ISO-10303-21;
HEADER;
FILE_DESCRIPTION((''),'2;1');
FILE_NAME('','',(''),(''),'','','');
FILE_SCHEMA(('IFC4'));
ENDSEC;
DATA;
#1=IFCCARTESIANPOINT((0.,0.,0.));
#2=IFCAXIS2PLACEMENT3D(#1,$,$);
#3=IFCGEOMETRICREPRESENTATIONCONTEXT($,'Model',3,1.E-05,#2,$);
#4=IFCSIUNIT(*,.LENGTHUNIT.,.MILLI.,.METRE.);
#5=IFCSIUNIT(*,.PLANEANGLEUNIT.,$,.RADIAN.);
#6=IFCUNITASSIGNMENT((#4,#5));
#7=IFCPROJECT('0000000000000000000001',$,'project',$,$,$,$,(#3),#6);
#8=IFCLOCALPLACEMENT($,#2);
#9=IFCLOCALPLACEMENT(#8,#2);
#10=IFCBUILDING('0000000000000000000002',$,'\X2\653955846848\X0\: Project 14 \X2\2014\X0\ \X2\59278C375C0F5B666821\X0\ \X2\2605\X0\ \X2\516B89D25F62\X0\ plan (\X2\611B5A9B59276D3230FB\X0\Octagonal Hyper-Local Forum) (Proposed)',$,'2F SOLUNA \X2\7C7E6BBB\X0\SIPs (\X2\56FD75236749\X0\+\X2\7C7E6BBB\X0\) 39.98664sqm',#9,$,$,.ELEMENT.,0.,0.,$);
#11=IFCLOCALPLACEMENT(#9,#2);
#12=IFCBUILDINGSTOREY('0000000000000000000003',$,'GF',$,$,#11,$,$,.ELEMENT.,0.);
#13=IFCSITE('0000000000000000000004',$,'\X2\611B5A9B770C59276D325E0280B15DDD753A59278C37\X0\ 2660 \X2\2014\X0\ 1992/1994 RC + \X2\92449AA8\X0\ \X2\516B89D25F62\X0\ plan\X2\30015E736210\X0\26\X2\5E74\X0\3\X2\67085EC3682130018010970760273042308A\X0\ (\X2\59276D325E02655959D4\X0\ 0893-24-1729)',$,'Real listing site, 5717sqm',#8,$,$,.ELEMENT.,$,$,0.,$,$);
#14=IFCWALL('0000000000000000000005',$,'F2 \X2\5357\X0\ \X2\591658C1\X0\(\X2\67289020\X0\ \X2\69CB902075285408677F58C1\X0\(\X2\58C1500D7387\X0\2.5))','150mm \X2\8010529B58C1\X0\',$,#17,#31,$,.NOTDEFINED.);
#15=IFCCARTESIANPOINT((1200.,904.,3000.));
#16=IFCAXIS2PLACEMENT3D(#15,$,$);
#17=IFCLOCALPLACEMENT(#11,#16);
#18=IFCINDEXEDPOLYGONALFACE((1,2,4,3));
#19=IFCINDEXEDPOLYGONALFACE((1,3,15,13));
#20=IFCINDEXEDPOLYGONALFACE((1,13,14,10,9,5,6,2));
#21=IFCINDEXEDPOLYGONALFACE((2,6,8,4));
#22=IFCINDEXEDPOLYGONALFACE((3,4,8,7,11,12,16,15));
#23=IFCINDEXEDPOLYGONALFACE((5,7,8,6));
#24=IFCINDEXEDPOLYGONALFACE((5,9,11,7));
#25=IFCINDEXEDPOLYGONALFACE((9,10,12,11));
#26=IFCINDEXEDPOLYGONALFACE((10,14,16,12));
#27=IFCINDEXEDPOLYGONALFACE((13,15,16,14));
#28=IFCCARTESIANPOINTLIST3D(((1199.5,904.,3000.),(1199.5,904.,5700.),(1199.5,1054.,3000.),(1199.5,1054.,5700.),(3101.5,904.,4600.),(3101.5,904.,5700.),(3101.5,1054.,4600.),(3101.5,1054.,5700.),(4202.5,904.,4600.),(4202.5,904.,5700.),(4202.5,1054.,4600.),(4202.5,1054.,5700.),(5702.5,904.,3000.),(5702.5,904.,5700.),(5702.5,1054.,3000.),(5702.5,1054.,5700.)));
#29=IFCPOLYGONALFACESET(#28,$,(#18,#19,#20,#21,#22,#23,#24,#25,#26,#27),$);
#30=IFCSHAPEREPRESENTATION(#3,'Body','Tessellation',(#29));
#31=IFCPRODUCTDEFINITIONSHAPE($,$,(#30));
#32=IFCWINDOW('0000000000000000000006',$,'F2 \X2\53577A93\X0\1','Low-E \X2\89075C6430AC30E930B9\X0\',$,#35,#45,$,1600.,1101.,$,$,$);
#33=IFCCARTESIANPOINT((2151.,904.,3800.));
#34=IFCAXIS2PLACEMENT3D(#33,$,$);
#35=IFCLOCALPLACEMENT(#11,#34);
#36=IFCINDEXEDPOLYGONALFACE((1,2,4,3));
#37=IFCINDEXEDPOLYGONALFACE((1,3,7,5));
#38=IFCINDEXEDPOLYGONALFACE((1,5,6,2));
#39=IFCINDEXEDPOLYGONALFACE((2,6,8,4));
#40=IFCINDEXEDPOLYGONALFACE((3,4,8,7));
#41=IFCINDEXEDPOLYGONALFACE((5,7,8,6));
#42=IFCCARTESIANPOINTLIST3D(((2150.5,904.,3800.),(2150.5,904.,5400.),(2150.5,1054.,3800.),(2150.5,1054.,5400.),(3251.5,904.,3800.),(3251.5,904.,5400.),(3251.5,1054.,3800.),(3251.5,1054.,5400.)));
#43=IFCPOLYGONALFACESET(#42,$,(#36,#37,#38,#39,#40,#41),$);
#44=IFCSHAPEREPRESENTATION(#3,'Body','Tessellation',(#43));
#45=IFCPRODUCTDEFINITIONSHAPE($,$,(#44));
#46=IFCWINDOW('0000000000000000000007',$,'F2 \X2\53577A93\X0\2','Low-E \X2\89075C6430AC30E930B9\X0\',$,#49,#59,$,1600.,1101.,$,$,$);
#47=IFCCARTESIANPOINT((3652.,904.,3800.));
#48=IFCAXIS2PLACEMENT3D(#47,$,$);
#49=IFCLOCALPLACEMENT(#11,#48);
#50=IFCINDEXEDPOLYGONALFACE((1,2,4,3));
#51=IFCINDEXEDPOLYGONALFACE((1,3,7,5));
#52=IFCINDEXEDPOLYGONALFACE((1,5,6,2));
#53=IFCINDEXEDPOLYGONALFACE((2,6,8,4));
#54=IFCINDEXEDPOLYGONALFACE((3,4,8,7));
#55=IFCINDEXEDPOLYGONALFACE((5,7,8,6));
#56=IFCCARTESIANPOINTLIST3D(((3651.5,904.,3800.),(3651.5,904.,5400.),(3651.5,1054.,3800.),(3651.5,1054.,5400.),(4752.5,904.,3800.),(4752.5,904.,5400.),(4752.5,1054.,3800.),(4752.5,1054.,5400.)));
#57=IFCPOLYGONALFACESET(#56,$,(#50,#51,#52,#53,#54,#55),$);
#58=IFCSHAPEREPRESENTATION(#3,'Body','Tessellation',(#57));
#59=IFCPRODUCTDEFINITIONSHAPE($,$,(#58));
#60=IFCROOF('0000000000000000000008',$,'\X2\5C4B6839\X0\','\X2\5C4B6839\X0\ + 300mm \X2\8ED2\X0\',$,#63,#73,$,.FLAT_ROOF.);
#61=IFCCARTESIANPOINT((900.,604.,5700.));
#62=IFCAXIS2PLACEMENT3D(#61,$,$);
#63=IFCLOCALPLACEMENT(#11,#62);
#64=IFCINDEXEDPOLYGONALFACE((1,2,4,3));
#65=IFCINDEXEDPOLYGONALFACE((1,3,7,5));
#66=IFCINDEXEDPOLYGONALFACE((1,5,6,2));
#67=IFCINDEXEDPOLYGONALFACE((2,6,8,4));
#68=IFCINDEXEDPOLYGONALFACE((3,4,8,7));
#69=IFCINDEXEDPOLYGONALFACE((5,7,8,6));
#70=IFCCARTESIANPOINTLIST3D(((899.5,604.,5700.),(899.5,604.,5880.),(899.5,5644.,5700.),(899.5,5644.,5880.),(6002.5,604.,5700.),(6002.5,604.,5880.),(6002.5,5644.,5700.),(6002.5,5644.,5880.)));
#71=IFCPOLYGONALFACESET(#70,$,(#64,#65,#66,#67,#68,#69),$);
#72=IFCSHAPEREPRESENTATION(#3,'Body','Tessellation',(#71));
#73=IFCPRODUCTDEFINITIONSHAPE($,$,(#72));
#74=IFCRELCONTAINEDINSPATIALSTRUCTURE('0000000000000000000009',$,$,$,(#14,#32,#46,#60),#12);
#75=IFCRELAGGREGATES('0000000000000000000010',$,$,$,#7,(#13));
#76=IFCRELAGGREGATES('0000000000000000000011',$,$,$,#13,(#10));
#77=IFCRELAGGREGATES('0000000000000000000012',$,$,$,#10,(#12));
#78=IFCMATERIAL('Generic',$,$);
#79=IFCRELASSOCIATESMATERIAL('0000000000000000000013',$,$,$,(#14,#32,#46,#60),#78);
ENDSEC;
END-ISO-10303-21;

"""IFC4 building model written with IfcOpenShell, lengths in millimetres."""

from ifc_helpers import new_model, si_unit, frame, frame_2d, origin, place, context, project, spatial, rectangle, extrude, material, element, fill, save


model = new_model("IFC4")

# Units and contexts
model_context = context("Model", 3, precision=1e-05, world=origin())
ifc_project = project(units=[si_unit("LENGTHUNIT", "METRE", prefix="MILLI"), si_unit("PLANEANGLEUNIT", "RADIAN")], contexts=[model_context])

# Site, building, storey
site_placement = place(None, origin())
site = spatial("IfcSite", under=ifc_project, at=site_placement, Name="愛媛県大洲市肱川町大谷 2660 — 1992/1994 RC + 鉄骨 八角形 plan、平成26年3月廃校、耐震性あり (大洲市教委 0893-24-1729)", ObjectType="Real listing site, 5717sqm", CompositionType="ELEMENT", RefElevation=0.0)
building_placement = place(site_placement, origin())
building = spatial("IfcBuilding", under=site, at=building_placement, Name="改善案: Project 14 — 大谷小学校 ★ 八角形 plan (愛媛大洲・Octagonal Hyper-Local Forum) (Proposed)", ObjectType="2F SOLUNA 籾殻SIPs (国産杉+籾殻) 39.98664sqm", CompositionType="ELEMENT", ElevationOfRefHeight=0.0, ElevationOfTerrain=0.0)
storey_placement = place(building_placement, origin())
storey = spatial("IfcBuildingStorey", under=building, at=storey_placement, Name="GF", CompositionType="ELEMENT", Elevation=0.0)

# Shared definitions
ifc_material_1 = material(Name="Generic")

# Wall, openings, windows
wall_1_placement = place(storey_placement, frame((1200.0, 904.0, 3000.0)))
wall_1 = element("IfcWall", 1, at=wall_1_placement, inside=storey, material=ifc_material_1, Name="F2 南 外壁(木造 構造用合板壁(壁倍率2.5))", Description="150mm 耐力壁", PredefinedType="NOTDEFINED", context=model_context, shape_type="SweptSolid", body=[
    extrude(rectangle(XDim=4503.0, YDim=150.0, at=frame_2d((2251.0, 75.0))), frame((1200.0, 904.0, 3000.0)), (0.0, 0.0, 1.0), 2700.0),
])
opening_1_placement = place(storey_placement, frame((2151.0, 904.0, 3800.0)))
opening_1 = element("IfcOpeningElement", 2, at=opening_1_placement, cuts=wall_1, PredefinedType="NOTDEFINED", context=model_context, shape_type="SweptSolid", body=[
    extrude(rectangle(XDim=1101.0, YDim=150.0, at=frame_2d((550.0, 75.0))), frame((2151.0, 904.0, 3800.0)), (0.0, 0.0, 1.0), 1600.0),
])
opening_2_placement = place(storey_placement, frame((3652.0, 904.0, 3800.0)))
opening_2 = element("IfcOpeningElement", 3, at=opening_2_placement, cuts=wall_1, PredefinedType="NOTDEFINED", context=model_context, shape_type="SweptSolid", body=[
    extrude(rectangle(XDim=1101.0, YDim=150.0, at=frame_2d((550.0, 75.0))), frame((3652.0, 904.0, 3800.0)), (0.0, 0.0, 1.0), 1600.0),
])
window_1_placement = place(storey_placement, frame((2151.0, 904.0, 3800.0)))
window_1 = element("IfcWindow", 4, at=window_1_placement, inside=storey, material=ifc_material_1, Name="F2 南窓1", Description="Low-E 複層ガラス", OverallHeight=1600.0, OverallWidth=1101.0, context=model_context, shape_type="SweptSolid", body=[
    extrude(rectangle(XDim=1101.0, YDim=150.0, at=frame_2d((550.0, 75.0))), frame((2151.0, 904.0, 3800.0)), (0.0, 0.0, 1.0), 1600.0),
])
fill(opening_1, window_1)
window_2_placement = place(storey_placement, frame((3652.0, 904.0, 3800.0)))
window_2 = element("IfcWindow", 5, at=window_2_placement, inside=storey, material=ifc_material_1, Name="F2 南窓2", Description="Low-E 複層ガラス", OverallHeight=1600.0, OverallWidth=1101.0, context=model_context, shape_type="SweptSolid", body=[
    extrude(rectangle(XDim=1101.0, YDim=150.0, at=frame_2d((550.0, 75.0))), frame((3652.0, 904.0, 3800.0)), (0.0, 0.0, 1.0), 1600.0),
])
fill(opening_2, window_2)

# Roof
roof_placement = place(storey_placement, frame((900.0, 604.0, 5700.0)))
element("IfcRoof", 6, at=roof_placement, inside=storey, material=ifc_material_1, Name="屋根", Description="屋根 + 300mm 軒", PredefinedType="FLAT_ROOF", context=model_context, shape_type="SweptSolid", body=[
    extrude(rectangle(XDim=5103.0, YDim=5040.0, at=frame_2d((2551.0, 2520.0))), frame((900.0, 604.0, 5700.0)), (0.0, 0.0, 1.0), 180.0),
])

save(model, "model.ifc")
